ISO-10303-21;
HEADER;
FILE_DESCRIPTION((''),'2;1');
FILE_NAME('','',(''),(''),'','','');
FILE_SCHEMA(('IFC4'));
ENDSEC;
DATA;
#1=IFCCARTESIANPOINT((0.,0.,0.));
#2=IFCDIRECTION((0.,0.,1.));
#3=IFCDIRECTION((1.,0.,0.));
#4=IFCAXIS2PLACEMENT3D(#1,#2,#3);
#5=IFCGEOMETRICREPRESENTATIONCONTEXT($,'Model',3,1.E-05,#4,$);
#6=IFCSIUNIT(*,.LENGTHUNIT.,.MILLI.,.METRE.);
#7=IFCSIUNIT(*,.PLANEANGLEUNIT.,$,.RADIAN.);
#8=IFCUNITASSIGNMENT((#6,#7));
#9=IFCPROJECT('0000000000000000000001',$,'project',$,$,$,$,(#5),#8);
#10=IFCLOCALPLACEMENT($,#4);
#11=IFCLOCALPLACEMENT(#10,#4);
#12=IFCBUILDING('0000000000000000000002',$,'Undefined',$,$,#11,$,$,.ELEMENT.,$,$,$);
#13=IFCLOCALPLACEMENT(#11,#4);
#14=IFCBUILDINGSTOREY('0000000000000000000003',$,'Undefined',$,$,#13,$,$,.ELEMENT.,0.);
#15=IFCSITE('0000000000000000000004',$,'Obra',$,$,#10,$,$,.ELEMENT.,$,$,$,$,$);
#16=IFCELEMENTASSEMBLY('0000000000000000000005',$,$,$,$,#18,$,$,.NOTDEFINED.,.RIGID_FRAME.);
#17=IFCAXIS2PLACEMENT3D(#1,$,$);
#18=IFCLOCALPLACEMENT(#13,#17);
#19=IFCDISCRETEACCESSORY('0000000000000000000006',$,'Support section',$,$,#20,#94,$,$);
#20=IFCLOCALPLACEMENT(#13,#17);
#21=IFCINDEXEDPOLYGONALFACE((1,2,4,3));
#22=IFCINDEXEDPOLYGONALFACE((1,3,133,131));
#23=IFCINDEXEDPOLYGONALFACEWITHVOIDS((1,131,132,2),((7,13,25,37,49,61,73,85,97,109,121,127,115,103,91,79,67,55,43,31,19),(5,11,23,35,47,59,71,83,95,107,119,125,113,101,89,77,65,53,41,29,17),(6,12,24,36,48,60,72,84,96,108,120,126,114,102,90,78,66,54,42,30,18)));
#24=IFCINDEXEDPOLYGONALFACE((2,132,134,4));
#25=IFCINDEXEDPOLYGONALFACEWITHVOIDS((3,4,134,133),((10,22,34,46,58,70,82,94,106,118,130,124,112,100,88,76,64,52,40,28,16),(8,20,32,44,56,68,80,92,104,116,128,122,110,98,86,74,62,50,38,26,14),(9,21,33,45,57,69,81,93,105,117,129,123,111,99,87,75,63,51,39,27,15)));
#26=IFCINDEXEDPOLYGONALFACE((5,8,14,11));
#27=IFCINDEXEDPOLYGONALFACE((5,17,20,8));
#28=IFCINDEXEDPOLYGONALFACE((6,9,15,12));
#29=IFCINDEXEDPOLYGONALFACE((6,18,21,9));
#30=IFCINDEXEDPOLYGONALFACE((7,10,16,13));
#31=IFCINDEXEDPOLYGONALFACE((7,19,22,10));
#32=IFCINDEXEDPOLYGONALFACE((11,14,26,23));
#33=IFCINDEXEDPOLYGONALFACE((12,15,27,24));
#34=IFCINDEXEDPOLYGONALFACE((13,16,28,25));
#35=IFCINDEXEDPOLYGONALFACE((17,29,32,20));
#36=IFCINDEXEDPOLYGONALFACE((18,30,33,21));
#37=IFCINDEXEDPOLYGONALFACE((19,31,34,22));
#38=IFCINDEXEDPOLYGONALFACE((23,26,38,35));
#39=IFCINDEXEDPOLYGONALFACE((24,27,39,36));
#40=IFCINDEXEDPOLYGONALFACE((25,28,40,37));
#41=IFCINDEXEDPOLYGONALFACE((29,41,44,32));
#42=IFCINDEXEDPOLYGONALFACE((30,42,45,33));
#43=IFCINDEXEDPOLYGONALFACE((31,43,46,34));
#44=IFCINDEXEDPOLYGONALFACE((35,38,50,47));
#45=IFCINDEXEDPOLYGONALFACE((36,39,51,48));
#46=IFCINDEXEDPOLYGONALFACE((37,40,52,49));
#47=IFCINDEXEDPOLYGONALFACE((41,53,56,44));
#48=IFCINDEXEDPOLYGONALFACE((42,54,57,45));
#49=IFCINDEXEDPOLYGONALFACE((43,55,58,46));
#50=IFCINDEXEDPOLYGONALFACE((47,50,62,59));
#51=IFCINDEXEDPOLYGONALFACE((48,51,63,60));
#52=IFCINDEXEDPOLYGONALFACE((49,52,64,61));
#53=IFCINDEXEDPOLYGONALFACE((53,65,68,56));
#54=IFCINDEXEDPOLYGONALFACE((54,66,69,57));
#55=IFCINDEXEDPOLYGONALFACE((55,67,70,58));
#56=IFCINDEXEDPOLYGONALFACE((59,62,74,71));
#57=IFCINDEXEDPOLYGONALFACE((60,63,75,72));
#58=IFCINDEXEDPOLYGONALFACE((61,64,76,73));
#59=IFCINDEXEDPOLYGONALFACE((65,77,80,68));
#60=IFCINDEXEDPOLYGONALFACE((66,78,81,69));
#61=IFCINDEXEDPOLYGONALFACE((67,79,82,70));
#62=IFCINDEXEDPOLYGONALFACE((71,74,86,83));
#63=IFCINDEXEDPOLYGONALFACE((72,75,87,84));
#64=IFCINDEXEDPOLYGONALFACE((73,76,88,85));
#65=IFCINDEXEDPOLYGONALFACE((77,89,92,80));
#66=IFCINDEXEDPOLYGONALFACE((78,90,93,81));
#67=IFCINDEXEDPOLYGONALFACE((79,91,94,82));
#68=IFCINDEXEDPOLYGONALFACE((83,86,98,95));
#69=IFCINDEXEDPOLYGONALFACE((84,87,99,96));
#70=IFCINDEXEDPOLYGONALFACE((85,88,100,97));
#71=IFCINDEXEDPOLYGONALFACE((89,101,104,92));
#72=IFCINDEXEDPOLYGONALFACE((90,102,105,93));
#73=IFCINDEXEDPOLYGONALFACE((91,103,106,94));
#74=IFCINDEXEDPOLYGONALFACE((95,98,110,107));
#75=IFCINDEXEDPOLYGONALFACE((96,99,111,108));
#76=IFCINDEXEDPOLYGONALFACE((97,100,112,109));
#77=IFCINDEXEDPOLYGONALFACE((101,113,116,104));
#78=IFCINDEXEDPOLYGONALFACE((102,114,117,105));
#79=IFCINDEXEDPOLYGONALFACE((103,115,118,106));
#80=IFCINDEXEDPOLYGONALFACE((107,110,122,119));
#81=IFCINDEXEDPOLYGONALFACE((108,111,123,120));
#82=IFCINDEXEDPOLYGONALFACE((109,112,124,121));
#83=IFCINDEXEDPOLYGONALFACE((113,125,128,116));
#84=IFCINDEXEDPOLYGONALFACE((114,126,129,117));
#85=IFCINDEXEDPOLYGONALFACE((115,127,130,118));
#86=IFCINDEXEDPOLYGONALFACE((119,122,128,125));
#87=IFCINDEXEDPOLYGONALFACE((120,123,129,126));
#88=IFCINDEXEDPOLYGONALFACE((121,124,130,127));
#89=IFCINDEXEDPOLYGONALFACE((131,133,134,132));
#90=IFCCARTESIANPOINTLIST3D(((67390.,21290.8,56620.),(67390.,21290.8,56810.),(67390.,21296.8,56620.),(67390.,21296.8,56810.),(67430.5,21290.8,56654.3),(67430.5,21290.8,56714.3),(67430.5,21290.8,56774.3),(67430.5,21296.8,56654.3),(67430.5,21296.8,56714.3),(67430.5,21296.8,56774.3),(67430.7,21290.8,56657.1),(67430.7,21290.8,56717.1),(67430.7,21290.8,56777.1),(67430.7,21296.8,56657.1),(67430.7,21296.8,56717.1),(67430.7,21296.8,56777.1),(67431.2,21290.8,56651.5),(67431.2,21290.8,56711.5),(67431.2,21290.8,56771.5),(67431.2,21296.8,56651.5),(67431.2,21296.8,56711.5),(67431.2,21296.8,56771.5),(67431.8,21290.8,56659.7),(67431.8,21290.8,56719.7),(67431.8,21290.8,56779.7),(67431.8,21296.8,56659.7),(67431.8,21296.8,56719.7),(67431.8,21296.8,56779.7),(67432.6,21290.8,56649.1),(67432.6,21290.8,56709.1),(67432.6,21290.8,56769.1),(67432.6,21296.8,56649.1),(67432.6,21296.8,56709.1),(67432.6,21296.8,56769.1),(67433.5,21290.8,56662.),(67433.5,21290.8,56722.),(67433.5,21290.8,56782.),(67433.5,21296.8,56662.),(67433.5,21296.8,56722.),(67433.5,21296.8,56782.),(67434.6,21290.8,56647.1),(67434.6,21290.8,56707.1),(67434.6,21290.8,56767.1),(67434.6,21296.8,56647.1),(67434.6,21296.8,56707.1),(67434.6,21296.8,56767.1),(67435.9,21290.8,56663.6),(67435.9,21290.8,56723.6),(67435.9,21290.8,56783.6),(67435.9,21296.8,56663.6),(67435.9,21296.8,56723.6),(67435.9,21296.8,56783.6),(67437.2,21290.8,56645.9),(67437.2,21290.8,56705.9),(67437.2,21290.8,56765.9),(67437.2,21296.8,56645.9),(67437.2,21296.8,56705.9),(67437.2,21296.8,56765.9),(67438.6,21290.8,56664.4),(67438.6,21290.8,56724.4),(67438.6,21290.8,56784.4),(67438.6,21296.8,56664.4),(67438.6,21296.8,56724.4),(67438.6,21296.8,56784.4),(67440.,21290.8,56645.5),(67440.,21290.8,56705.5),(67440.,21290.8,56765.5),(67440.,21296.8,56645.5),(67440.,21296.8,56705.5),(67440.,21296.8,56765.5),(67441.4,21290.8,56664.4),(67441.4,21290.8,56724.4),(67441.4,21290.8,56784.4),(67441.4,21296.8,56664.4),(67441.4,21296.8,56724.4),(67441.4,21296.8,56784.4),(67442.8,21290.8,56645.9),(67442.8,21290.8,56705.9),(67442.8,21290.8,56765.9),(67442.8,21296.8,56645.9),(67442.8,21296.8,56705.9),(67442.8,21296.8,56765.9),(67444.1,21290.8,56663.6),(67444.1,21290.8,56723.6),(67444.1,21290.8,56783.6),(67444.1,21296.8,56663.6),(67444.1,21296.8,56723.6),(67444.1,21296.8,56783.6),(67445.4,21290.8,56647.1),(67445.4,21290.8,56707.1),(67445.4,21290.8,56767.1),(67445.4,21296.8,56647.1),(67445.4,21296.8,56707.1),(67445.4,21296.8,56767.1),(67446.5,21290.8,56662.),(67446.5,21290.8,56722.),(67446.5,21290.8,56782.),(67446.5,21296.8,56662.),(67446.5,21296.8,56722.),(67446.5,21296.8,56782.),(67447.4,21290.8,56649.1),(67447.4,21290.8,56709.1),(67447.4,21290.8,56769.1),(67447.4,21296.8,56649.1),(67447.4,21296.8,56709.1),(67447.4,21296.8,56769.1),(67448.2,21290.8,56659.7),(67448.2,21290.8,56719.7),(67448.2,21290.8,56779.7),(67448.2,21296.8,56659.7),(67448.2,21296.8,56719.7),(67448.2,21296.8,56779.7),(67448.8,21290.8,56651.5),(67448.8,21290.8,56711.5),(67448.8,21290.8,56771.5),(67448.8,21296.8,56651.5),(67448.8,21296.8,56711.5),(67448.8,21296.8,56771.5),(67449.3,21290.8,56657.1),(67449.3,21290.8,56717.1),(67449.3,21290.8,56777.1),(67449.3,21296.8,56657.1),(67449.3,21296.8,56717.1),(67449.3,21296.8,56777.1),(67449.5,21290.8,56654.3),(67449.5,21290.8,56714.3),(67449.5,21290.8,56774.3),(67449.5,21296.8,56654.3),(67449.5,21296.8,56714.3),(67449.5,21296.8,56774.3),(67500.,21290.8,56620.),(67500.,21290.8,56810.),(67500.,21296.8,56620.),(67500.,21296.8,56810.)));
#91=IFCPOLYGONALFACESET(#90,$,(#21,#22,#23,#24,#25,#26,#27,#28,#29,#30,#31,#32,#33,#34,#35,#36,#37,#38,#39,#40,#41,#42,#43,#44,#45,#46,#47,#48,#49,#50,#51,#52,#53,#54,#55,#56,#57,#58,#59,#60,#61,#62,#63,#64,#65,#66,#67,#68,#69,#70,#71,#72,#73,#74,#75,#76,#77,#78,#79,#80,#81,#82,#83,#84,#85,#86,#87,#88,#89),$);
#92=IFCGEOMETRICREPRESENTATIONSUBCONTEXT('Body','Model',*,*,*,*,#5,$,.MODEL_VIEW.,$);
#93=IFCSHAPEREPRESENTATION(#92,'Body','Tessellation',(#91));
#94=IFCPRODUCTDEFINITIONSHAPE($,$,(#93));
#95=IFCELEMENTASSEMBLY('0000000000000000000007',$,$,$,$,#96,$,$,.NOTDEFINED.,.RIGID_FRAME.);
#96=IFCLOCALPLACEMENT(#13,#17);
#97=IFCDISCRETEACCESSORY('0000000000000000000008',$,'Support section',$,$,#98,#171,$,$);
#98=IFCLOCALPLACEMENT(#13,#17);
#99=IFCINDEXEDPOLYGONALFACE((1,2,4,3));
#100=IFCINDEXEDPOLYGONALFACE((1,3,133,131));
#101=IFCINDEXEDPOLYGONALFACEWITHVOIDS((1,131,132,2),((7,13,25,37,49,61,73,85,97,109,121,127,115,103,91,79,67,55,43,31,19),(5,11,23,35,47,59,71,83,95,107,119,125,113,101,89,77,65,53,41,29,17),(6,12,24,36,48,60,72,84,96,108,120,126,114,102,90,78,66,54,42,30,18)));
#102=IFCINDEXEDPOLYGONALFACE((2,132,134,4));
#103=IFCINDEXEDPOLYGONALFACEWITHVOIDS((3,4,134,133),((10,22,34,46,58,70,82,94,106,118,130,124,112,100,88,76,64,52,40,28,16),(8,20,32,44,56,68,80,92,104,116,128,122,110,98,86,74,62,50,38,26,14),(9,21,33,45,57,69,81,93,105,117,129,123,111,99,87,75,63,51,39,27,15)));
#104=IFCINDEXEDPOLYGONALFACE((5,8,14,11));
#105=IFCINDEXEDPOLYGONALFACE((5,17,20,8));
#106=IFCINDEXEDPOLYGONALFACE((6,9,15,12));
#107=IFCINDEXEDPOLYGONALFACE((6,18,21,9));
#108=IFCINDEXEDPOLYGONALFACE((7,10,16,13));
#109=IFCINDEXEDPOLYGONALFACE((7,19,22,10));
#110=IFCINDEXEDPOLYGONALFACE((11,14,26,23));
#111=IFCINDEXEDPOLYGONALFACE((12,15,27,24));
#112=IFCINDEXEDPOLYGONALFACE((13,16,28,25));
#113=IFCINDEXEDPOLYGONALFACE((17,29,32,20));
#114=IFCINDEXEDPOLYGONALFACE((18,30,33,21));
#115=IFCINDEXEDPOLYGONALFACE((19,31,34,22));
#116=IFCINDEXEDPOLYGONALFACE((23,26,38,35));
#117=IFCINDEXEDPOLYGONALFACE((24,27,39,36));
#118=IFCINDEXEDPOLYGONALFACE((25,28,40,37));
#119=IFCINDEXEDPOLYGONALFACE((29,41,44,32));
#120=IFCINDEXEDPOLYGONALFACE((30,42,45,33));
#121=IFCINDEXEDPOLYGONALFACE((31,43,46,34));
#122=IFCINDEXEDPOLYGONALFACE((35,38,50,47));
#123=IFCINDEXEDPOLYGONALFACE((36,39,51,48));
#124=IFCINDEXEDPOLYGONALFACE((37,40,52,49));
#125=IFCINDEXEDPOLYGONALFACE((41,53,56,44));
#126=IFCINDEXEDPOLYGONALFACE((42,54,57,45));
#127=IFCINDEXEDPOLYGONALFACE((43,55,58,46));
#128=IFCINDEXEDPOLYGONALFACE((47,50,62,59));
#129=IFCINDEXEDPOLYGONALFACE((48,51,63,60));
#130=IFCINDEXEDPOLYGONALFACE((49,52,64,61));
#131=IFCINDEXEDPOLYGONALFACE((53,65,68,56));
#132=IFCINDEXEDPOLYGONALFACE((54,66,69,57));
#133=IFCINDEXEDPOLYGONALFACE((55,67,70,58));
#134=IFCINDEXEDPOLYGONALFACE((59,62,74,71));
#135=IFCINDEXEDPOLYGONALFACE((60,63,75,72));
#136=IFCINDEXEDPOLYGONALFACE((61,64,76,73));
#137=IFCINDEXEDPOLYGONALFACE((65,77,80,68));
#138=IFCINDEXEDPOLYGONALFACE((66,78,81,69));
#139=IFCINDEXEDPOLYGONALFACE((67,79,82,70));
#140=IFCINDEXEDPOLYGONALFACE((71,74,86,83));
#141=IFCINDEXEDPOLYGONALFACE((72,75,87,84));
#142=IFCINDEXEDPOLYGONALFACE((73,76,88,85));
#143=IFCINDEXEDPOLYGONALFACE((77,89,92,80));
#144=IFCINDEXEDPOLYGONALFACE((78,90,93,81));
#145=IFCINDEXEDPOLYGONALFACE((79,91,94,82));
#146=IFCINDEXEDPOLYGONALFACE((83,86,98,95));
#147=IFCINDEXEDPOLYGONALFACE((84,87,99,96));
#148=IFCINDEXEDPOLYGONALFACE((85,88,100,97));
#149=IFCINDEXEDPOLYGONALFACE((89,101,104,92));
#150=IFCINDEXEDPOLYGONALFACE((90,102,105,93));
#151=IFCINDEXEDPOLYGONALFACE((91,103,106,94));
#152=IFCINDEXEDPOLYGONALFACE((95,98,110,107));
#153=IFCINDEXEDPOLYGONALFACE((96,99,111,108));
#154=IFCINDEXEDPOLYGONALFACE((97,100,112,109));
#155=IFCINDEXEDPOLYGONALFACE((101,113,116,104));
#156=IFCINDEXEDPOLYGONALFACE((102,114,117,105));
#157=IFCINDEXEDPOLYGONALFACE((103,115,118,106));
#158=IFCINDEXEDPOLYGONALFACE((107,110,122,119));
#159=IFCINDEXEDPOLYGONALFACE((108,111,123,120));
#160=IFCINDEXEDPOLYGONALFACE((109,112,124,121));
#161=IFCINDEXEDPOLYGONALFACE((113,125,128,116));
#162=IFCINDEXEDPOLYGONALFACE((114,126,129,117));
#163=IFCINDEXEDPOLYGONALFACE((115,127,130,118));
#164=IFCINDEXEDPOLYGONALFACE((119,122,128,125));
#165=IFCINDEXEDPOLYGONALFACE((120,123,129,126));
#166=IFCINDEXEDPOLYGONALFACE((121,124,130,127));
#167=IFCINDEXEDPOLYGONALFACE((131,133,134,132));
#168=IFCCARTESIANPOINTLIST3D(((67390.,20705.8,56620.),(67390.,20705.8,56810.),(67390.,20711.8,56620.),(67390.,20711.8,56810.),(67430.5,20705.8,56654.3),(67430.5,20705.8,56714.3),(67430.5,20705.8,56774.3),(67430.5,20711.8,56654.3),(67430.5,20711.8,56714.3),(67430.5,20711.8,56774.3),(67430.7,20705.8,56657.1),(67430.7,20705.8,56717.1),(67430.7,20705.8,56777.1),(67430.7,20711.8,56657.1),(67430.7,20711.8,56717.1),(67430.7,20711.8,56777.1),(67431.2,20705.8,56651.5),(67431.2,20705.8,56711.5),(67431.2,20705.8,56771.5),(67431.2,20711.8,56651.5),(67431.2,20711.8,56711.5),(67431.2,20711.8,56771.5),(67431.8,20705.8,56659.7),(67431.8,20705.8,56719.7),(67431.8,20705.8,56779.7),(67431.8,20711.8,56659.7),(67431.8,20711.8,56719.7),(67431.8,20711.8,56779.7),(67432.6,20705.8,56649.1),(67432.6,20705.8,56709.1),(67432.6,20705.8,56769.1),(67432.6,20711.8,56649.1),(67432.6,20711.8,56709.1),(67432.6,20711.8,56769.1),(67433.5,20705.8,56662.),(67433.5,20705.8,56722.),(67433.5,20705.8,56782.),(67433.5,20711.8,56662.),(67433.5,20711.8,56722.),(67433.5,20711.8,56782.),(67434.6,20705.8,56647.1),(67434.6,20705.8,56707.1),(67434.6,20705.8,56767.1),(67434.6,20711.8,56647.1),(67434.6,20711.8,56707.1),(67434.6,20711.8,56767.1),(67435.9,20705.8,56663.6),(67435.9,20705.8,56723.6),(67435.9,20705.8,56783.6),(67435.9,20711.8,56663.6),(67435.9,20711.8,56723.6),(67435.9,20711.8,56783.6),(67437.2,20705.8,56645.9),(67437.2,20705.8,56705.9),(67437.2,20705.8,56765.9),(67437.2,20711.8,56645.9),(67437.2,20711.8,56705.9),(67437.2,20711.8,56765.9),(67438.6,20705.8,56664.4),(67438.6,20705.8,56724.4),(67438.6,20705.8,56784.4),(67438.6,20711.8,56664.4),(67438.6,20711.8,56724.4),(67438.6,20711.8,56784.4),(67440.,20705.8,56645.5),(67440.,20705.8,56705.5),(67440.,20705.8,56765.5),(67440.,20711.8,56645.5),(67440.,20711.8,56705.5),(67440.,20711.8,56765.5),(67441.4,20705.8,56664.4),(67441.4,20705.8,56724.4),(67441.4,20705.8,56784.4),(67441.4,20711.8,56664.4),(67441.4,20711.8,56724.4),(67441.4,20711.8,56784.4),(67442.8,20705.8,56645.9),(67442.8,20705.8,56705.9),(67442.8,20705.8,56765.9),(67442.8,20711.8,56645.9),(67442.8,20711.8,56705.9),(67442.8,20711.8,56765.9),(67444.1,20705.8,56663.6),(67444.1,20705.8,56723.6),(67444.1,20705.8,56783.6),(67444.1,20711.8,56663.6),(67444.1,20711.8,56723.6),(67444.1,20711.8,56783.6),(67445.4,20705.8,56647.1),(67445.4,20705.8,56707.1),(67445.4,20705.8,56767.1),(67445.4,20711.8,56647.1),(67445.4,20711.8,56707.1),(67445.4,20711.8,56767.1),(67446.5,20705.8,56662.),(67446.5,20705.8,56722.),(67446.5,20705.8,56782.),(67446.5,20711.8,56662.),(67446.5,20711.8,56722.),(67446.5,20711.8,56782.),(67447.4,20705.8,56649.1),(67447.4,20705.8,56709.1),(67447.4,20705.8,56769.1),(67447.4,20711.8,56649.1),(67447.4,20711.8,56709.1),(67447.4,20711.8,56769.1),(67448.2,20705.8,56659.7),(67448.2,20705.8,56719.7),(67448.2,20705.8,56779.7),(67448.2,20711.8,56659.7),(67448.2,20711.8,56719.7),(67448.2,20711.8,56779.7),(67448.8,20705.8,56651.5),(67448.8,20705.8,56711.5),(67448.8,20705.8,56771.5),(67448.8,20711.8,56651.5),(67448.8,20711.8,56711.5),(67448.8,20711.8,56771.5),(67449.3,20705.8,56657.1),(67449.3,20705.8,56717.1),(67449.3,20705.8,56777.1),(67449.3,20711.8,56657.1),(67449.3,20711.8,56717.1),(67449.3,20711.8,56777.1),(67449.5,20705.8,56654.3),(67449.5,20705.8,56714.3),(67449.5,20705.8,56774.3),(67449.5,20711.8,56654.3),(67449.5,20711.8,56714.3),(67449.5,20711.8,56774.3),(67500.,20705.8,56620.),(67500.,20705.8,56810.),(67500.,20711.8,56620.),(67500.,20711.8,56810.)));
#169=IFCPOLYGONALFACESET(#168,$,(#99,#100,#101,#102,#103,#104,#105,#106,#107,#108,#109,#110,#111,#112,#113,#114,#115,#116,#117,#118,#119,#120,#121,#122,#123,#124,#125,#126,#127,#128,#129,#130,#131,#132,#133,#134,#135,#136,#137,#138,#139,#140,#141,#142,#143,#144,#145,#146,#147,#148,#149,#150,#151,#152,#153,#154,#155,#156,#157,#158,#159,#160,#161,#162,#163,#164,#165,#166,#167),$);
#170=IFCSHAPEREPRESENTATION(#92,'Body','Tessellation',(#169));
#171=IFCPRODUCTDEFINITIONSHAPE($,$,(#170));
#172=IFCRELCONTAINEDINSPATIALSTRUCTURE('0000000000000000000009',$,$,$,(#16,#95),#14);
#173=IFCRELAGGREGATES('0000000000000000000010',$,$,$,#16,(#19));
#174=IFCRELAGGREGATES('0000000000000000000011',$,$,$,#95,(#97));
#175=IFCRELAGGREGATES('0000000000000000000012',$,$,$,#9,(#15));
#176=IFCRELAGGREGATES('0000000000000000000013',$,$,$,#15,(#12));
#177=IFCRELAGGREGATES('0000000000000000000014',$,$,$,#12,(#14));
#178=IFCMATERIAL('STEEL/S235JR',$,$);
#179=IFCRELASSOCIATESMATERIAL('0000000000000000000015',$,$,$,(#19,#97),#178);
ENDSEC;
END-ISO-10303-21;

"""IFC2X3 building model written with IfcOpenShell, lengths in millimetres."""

from ifc_helpers import new_model, si_unit, frame, origin_with_axes, origin_2d_with_axis, place, context, subcontext, project, spatial, rectangle, circle, extrude, source, transform, mapped, material, element, aggregate, save


model = new_model("IFC2X3")

# Units and contexts
model_context = context("Model", 3, precision=1e-05, world=origin_with_axes())
body_context = subcontext(model_context, "Body", "Model", "MODEL_VIEW")
ifc_project = project(units=[si_unit("LENGTHUNIT", "METRE", prefix="MILLI"), si_unit("PLANEANGLEUNIT", "RADIAN")], contexts=[model_context])

# Site, building, storey
site_placement = place(None, origin_with_axes())
site = spatial("IfcSite", under=ifc_project, at=site_placement, Name="Obra", CompositionType="ELEMENT")
building_placement = place(site_placement, origin_with_axes())
building = spatial("IfcBuilding", under=site, at=building_placement, Name="Undefined", CompositionType="ELEMENT")
storey_placement = place(building_placement, origin_with_axes())
storey = spatial("IfcBuildingStorey", under=building, at=storey_placement, Name="Undefined", CompositionType="ELEMENT", Elevation=0.0)

# Shared definitions
ifc_material = material(Name="STEEL/S235JR")

# Element assemblies, discrete accessories, openings
shared_shape_1 = source(origin_with_axes(), body_context, "Body", "SweptSolid", [
    extrude(circle(Radius=9.5, at=origin_2d_with_axis()), frame((0.0, -9.2, 0.0), z_axis=(0.0, 1.0, 0.0), x_axis=(1.0, 0.0, 0.0)), (0.0, 0.0, 1.0), 6.2),
])
assembly_1_placement = place(storey_placement, origin_with_axes())
assembly_1 = element("IfcElementAssembly", 1, at=assembly_1_placement, inside=storey, AssemblyPlace="NOTDEFINED", PredefinedType="RIGID_FRAME")
discrete_accessory_1_placement = place(assembly_1_placement, frame((67445.0, 21293.8, 56620.0), z_axis=(0.0, 0.0, 1.0), x_axis=(1.0, 0.0, 0.0)))
discrete_accessory_1 = element("IfcDiscreteAccessory", 2, at=discrete_accessory_1_placement, material=ifc_material, Name="Support section", context=body_context, shape_type="SweptSolid", body=[
    extrude(rectangle(XDim=6.0, YDim=110.0, at=origin_2d_with_axis()), frame((0.0, 0.0, 190.0), z_axis=(0.0, 0.0, -1.0), x_axis=(0.0, 1.0, 0.0)), (0.0, 0.0, 1.0), 190.0),
])
opening_1_placement = place(assembly_1_placement, frame((67490.0, 21287.7, 56835.0), z_axis=(-1.0, 0.0, 0.0), x_axis=(0.0, 0.0, -1.0)))
element("IfcOpeningElement", 3, at=opening_1_placement, cuts=discrete_accessory_1, ObjectType="Opening", context=body_context, shape_type="MappedRepresentation", body=[
    mapped(shared_shape_1, transform((60.0, 0.0, 50.0))),
    mapped(shared_shape_1, transform((120.0, 0.0, 50.0))),
    mapped(shared_shape_1, transform((180.0, 0.0, 50.0))),
])
aggregate(assembly_1, [discrete_accessory_1])
assembly_2_placement = place(storey_placement, origin_with_axes())
assembly_2 = element("IfcElementAssembly", 4, at=assembly_2_placement, inside=storey, AssemblyPlace="NOTDEFINED", PredefinedType="RIGID_FRAME")
discrete_accessory_2_placement = place(assembly_2_placement, frame((67445.0, 20708.8, 56620.0), z_axis=(0.0, 0.0, 1.0), x_axis=(1.0, 0.0, 0.0)))
discrete_accessory_2 = element("IfcDiscreteAccessory", 5, at=discrete_accessory_2_placement, material=ifc_material, Name="Support section", context=body_context, shape_type="SweptSolid", body=[
    extrude(rectangle(XDim=6.0, YDim=110.0, at=origin_2d_with_axis()), frame((0.0, 0.0, 190.0), z_axis=(0.0, 0.0, -1.0), x_axis=(0.0, 1.0, 0.0)), (0.0, 0.0, 1.0), 190.0),
])
opening_2_placement = place(assembly_2_placement, frame((67490.0, 20702.7, 56835.0), z_axis=(-1.0, 0.0, 0.0), x_axis=(0.0, 0.0, -1.0)))
element("IfcOpeningElement", 6, at=opening_2_placement, cuts=discrete_accessory_2, ObjectType="Opening", context=body_context, shape_type="MappedRepresentation", body=[
    mapped(shared_shape_1, transform((60.0, 0.0, 50.0))),
    mapped(shared_shape_1, transform((120.0, 0.0, 50.0))),
    mapped(shared_shape_1, transform((180.0, 0.0, 50.0))),
])
aggregate(assembly_2, [discrete_accessory_2])

save(model, "model.ifc")
